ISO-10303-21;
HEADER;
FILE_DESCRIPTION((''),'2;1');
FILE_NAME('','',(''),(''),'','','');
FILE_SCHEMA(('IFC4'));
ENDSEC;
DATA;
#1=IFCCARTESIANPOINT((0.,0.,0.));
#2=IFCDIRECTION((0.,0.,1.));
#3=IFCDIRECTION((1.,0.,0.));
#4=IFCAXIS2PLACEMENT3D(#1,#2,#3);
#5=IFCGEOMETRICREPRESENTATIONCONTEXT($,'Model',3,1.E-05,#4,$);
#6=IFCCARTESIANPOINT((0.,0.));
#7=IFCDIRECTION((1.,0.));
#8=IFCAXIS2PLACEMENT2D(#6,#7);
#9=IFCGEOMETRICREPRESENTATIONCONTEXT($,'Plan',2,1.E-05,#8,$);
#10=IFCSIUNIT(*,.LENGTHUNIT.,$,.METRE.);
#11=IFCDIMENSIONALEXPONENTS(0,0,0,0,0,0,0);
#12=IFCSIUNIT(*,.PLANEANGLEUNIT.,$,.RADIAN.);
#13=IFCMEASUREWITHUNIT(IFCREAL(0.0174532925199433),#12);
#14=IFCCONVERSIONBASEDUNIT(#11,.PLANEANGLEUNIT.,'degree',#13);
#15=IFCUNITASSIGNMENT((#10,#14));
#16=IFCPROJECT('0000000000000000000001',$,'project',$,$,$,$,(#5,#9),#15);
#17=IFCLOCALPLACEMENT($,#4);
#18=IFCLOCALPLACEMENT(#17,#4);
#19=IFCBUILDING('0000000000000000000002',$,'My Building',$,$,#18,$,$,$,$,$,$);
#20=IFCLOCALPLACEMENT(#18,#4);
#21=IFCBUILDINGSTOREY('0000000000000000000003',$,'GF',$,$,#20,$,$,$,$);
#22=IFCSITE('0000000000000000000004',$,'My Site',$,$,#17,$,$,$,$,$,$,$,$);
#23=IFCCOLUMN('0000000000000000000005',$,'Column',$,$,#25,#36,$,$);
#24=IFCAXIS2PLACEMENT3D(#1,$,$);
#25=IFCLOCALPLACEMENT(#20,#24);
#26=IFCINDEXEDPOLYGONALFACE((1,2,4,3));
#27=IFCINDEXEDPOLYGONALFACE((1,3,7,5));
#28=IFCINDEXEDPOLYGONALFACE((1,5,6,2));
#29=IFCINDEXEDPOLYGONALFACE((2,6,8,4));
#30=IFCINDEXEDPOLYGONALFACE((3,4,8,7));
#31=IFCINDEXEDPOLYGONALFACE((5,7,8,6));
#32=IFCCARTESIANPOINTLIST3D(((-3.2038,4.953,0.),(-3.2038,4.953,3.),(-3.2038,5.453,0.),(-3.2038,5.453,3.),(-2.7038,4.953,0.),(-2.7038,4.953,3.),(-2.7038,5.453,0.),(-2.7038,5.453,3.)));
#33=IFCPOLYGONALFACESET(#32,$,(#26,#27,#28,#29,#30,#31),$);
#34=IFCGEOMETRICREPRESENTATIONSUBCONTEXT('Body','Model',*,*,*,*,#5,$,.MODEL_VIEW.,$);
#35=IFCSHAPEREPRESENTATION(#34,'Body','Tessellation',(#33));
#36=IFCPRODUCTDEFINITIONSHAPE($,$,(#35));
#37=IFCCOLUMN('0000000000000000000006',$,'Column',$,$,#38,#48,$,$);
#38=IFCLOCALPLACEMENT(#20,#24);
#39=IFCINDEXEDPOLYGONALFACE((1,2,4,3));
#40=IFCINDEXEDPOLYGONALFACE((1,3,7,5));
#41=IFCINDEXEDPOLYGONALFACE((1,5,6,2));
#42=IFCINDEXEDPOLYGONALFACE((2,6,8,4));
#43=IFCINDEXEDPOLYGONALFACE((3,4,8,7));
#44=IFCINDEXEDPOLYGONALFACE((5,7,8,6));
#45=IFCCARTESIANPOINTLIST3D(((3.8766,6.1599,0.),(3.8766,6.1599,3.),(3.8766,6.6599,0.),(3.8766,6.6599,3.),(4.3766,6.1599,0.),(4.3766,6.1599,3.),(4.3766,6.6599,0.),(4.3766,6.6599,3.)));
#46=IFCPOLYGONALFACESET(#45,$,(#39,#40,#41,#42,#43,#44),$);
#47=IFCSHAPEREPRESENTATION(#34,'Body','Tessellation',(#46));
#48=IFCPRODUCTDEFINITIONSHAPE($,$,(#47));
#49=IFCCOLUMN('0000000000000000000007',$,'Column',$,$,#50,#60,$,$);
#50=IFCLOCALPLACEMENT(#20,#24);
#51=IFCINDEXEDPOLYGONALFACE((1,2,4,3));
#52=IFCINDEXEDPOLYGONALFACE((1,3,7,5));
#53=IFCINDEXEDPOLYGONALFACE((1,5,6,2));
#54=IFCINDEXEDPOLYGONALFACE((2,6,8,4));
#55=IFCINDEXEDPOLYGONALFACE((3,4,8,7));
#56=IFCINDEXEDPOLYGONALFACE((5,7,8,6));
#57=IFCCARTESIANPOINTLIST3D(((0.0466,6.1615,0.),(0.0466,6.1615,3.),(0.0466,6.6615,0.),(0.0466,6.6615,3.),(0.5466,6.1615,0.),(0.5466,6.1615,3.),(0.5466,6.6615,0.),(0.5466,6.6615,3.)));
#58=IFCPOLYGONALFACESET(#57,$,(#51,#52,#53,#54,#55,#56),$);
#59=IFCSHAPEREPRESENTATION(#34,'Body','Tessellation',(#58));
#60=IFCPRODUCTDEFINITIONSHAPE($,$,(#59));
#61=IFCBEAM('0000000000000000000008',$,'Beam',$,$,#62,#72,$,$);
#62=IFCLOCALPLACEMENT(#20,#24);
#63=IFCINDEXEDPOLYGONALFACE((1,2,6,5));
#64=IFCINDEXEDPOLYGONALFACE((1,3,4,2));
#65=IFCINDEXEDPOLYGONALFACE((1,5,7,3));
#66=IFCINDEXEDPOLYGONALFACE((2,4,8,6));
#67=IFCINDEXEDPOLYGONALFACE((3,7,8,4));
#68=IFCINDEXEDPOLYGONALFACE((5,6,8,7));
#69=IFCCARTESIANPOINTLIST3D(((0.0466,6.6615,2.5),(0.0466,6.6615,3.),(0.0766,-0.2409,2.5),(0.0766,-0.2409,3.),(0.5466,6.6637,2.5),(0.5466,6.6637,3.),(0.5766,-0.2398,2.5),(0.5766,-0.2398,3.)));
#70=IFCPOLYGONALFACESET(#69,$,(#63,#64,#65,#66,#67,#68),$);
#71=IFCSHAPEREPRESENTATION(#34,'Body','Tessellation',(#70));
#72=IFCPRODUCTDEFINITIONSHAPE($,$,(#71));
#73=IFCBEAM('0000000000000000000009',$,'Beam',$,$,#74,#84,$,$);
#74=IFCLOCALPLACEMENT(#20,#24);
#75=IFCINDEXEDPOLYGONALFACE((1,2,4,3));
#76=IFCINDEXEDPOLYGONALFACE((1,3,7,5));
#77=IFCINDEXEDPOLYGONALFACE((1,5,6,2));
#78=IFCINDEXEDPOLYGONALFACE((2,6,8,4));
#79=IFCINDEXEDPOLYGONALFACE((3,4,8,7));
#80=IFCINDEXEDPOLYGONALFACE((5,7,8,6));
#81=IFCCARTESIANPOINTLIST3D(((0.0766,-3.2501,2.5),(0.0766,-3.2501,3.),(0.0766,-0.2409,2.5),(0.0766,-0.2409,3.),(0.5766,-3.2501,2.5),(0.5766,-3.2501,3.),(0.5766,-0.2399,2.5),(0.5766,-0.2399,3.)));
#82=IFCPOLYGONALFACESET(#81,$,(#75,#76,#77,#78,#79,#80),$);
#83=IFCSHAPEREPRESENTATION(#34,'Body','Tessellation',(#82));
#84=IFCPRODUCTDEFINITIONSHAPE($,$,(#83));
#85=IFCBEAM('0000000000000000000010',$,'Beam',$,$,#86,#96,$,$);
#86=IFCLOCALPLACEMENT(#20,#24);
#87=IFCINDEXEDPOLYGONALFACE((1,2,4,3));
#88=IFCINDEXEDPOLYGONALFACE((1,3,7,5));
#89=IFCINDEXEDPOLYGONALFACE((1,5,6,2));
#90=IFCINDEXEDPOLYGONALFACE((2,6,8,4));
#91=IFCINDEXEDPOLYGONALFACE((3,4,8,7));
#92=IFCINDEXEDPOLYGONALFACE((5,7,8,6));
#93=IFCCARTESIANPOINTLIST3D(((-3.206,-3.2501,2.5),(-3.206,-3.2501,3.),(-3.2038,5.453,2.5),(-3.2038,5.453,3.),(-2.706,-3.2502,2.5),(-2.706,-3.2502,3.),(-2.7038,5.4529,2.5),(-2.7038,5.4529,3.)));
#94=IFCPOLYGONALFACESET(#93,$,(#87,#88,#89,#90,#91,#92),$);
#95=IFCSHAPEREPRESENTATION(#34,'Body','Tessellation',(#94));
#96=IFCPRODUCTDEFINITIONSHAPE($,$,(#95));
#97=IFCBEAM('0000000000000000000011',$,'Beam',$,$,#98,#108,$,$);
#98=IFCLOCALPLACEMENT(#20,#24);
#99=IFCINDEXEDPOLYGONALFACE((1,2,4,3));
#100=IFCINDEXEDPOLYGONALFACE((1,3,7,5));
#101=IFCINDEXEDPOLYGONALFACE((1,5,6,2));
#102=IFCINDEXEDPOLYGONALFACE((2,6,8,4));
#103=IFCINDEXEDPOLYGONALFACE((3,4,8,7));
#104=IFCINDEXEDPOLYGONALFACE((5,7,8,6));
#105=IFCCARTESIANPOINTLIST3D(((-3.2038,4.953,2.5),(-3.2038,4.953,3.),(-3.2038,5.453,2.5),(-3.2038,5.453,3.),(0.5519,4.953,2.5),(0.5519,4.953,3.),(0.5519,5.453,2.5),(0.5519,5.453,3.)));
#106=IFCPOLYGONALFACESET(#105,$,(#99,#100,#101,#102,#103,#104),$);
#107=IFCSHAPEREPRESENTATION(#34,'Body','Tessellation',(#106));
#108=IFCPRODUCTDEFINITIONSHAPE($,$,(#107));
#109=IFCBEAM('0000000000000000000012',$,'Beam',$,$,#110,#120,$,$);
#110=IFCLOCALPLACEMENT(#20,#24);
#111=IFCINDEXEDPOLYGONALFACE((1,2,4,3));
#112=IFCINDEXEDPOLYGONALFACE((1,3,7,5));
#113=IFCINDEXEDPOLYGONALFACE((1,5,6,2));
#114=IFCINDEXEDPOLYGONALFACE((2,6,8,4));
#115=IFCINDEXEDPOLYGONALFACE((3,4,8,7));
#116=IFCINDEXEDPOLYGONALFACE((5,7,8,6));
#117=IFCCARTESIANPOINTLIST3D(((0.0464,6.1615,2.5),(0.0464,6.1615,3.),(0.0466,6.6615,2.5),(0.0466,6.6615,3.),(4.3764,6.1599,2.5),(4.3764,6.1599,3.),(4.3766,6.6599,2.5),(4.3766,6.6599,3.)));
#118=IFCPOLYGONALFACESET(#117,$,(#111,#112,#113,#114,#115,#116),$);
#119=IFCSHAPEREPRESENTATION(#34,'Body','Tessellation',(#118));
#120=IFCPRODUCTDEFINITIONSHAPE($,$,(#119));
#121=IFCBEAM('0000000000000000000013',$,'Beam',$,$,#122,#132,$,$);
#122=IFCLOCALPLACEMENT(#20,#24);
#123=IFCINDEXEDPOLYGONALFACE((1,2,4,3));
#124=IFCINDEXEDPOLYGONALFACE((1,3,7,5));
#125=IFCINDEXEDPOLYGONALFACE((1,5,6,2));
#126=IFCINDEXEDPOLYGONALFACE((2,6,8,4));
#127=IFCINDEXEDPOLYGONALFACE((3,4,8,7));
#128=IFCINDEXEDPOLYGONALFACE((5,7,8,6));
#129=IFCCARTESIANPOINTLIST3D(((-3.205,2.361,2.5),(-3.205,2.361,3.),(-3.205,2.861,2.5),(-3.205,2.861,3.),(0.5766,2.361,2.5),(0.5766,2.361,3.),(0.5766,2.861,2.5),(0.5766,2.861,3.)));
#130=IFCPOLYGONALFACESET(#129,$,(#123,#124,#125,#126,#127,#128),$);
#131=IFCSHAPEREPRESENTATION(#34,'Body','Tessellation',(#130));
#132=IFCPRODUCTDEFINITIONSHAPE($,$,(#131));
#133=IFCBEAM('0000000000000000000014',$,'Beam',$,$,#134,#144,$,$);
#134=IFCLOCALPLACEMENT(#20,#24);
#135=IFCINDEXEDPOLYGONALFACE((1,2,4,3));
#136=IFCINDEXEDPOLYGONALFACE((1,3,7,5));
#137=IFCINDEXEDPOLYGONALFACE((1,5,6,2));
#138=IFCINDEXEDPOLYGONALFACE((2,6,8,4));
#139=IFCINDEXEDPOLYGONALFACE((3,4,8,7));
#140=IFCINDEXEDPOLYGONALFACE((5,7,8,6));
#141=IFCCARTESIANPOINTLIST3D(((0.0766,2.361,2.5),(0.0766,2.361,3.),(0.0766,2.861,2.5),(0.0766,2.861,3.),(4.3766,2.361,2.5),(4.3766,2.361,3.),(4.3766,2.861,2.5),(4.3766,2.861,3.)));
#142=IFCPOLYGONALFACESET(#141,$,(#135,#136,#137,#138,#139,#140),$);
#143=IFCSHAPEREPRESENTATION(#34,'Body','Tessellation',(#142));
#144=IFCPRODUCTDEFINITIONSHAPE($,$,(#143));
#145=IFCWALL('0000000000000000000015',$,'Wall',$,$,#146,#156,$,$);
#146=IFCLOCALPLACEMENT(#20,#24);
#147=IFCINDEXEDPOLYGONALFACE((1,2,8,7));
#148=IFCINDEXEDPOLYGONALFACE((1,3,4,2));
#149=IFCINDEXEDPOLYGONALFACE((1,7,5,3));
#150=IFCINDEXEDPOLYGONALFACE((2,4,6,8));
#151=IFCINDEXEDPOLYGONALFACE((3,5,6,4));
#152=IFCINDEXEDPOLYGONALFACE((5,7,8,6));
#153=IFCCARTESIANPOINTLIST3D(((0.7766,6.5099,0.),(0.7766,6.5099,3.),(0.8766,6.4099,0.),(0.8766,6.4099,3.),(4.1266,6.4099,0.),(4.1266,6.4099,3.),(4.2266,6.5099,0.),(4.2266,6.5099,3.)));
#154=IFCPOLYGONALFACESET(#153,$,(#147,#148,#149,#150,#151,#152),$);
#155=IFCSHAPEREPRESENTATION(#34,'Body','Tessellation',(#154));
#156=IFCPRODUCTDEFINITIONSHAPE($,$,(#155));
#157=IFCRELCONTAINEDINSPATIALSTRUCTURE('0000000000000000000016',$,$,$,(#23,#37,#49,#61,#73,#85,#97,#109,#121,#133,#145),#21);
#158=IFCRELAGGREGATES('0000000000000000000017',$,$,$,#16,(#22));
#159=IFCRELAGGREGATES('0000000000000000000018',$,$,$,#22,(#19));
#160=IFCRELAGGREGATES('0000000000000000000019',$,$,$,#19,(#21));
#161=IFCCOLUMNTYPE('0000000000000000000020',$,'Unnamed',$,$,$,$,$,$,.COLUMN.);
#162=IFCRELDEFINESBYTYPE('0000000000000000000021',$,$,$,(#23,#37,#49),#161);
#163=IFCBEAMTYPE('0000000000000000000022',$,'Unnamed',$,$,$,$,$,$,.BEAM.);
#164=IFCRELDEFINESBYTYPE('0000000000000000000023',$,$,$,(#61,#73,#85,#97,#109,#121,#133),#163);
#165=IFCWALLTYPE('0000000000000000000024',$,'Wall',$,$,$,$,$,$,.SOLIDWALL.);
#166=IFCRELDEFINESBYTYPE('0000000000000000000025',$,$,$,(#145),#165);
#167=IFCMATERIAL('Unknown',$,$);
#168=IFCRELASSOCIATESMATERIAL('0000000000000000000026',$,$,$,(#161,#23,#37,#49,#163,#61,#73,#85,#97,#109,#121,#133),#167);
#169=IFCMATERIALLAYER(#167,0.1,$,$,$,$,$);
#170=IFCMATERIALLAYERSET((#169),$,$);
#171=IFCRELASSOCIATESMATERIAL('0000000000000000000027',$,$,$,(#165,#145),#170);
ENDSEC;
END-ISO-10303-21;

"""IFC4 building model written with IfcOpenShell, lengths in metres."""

from ifc_helpers import new_model, entity, si_unit, converted_unit, frame, origin_with_axes, origin_2d_with_axis, place, context, subcontext, project, spatial, line, indexed_curve, rectangle, outline, extrude, clip, halfspace, material, layer, layer_set, layer_usage, material_profile, profile_set, profile_usage, type_object, element, save


model = new_model("IFC4")

# Units and contexts
model_context = context("Model", 3, precision=1e-05, world=origin_with_axes())
plan_context = context("Plan", 2, precision=1e-05, world=origin_2d_with_axis())
body_context_1 = subcontext(model_context, "Body", "Model", "MODEL_VIEW")
ifc_project = project(units=[si_unit("LENGTHUNIT", "METRE"), converted_unit("PLANEANGLEUNIT", "degree", entity("IfcReal", 0.0174532925199433), si_unit("PLANEANGLEUNIT", "RADIAN"), dimensions=[0, 0, 0, 0, 0, 0, 0])], contexts=[model_context, plan_context])

# Site, building, storey
site_placement = place(None, origin_with_axes())
site = spatial("IfcSite", under=ifc_project, at=site_placement, Name="My Site")
building_placement = place(site_placement, origin_with_axes())
building = spatial("IfcBuilding", under=site, at=building_placement, Name="My Building")
storey_placement = place(building_placement, origin_with_axes())
storey = spatial("IfcBuildingStorey", under=building, at=storey_placement, Name="GF")

# Columns
ifc_material_1 = material(Name="Unknown")
ifc_material_profile_1 = material_profile(ifc_material_1, rectangle(XDim=0.5, YDim=0.5))
ifc_profile_set_1 = profile_set([ifc_material_profile_1])
ifc_profile_usage_1 = profile_usage(ifc_profile_set_1, cardinal=5)
column_type = type_object("IfcColumnType", Name="Unnamed", PredefinedType="COLUMN", material=ifc_profile_set_1)
column_1_placement = place(storey_placement, frame((-2.9538, 5.203, 0.0), z_axis=(0.0, 0.0, 1.0), x_axis=(1.0, 0.0, 0.0)))
element("IfcColumn", 1, at=column_1_placement, inside=storey, type_object=column_type, material=ifc_profile_usage_1, Name="Column", context=body_context_1, shape_type="SweptSolid", body=[
    extrude(rectangle(XDim=0.5, YDim=0.5), origin_with_axes(), (0.0, 0.0, 1.0), 3.0),
])
ifc_profile_usage_2 = profile_usage(ifc_profile_set_1, cardinal=5)
column_2_placement = place(storey_placement, frame((4.1266, 6.4099, 0.0), z_axis=(0.0, 0.0, 1.0), x_axis=(1.0, 0.0, 0.0)))
element("IfcColumn", 2, at=column_2_placement, inside=storey, type_object=column_type, material=ifc_profile_usage_2, Name="Column", context=body_context_1, shape_type="SweptSolid", body=[
    extrude(rectangle(XDim=0.5, YDim=0.5), origin_with_axes(), (0.0, 0.0, 1.0), 3.0),
])
ifc_profile_usage_3 = profile_usage(ifc_profile_set_1, cardinal=5)
column_3_placement = place(storey_placement, frame((0.2966, 6.4115, 0.0), z_axis=(0.0, 0.0, 1.0), x_axis=(1.0, 0.0, 0.0)))
element("IfcColumn", 3, at=column_3_placement, inside=storey, type_object=column_type, material=ifc_profile_usage_3, Name="Column", context=body_context_1, shape_type="SweptSolid", body=[
    extrude(rectangle(XDim=0.5, YDim=0.5), origin_with_axes(), (0.0, 0.0, 1.0), 3.0),
])

# Beams
ifc_material_profile_2 = material_profile(ifc_material_1, rectangle(XDim=0.5, YDim=0.5))
ifc_profile_set_2 = profile_set([ifc_material_profile_2])
ifc_profile_usage_4 = profile_usage(ifc_profile_set_2, cardinal=9)
beam_type = type_object("IfcBeamType", Name="Unnamed", PredefinedType="BEAM", material=ifc_profile_set_2)
beam_1_placement = place(storey_placement, frame((0.0466, 6.6615, 3.0), z_axis=(0.004356, -0.999991, 0.0), x_axis=(0.999991, 0.004356, 0.0)))
element("IfcBeam", 4, at=beam_1_placement, inside=storey, type_object=beam_type, material=ifc_profile_usage_4, Name="Beam", context=body_context_1, shape_type="Clipping", body=[
    clip(extrude(rectangle(XDim=0.5, YDim=0.5), frame((0.25, -0.25, 0.0), z_axis=(0.0, 0.0, 1.0), x_axis=(1.0, 0.0, 0.0)), (0.0, 0.0, 1.0), 121.9591), halfspace(frame((0.5, -3.0, 6.9036), z_axis=(-0.002196, 0.0, 0.999998), x_axis=(-0.999998, 0.0, -0.002196)), False)),
])
ifc_profile_usage_5 = profile_usage(ifc_profile_set_2, cardinal=9)
beam_2_placement = place(storey_placement, frame((0.0776, 114.8156, 3.0), z_axis=(-0.000009, -1.0, 0.0), x_axis=(1.0, -0.000009, 0.0)))
element("IfcBeam", 5, at=beam_2_placement, inside=storey, type_object=beam_type, material=ifc_profile_usage_5, Name="Beam", context=body_context_1, shape_type="Clipping", body=[
    clip(extrude(rectangle(XDim=0.5, YDim=0.5), frame((0.25, -0.25, 0.0), z_axis=(0.0, 0.0, 1.0), x_axis=(1.0, 0.0, 0.0)), (0.0, 0.0, 1.0), 118.0658), halfspace(frame((0.5, -3.0, 115.0555), z_axis=(-0.002169, 0.0, -0.999998), x_axis=(0.999998, 0.0, -0.002169)), False)),
])
ifc_profile_usage_6 = profile_usage(ifc_profile_set_2, cardinal=9)
beam_3_placement = place(storey_placement, frame((-3.2038, 5.453, 3.0), z_axis=(-0.000251, -1.0, 0.0), x_axis=(1.0, -0.000251, 0.0)))
element("IfcBeam", 6, at=beam_3_placement, inside=storey, type_object=beam_type, material=ifc_profile_usage_6, Name="Beam", context=body_context_1, shape_type="SweptSolid", body=[
    extrude(rectangle(XDim=0.5, YDim=0.5), frame((0.25, -0.25, 0.0), z_axis=(0.0, 0.0, 1.0), x_axis=(1.0, 0.0, 0.0)), (0.0, 0.0, 1.0), 8.7031),
])
ifc_profile_usage_7 = profile_usage(ifc_profile_set_2, cardinal=7)
beam_4_placement = place(storey_placement, frame((-3.2038, 5.453, 3.0), z_axis=(1.0, 0.0, 0.0), x_axis=(0.0, 1.0, 0.0)))
element("IfcBeam", 7, at=beam_4_placement, inside=storey, type_object=beam_type, material=ifc_profile_usage_7, Name="Beam", context=body_context_1, shape_type="SweptSolid", body=[
    extrude(rectangle(XDim=0.5, YDim=0.5), frame((-0.25, -0.25, 0.0), z_axis=(0.0, 0.0, 1.0), x_axis=(1.0, 0.0, 0.0)), (0.0, 0.0, 1.0), 3.7558),
])
ifc_profile_usage_8 = profile_usage(ifc_profile_set_2, cardinal=7)
beam_5_placement = place(storey_placement, frame((0.0466, 6.6615, 3.0), z_axis=(1.0, -0.000377, 0.0), x_axis=(0.000377, 1.0, 0.0)))
element("IfcBeam", 8, at=beam_5_placement, inside=storey, type_object=beam_type, material=ifc_profile_usage_8, Name="Beam", context=body_context_1, shape_type="SweptSolid", body=[
    extrude(rectangle(XDim=0.5, YDim=0.5), frame((-0.25, -0.25, 0.0), z_axis=(0.0, 0.0, 1.0), x_axis=(1.0, 0.0, 0.0)), (0.0, 0.0, 1.0), 4.33),
])
ifc_profile_usage_9 = profile_usage(ifc_profile_set_2, cardinal=7)
beam_6_placement = place(storey_placement, frame((-3.205, 2.861, 3.0), z_axis=(1.0, 0.000001, 0.0), x_axis=(-0.000001, 1.0, 0.0)))
element("IfcBeam", 9, at=beam_6_placement, inside=storey, type_object=beam_type, material=ifc_profile_usage_9, Name="Beam", context=body_context_1, shape_type="SweptSolid", body=[
    extrude(rectangle(XDim=0.5, YDim=0.5), frame((-0.25, -0.25, 0.0), z_axis=(0.0, 0.0, 1.0), x_axis=(1.0, 0.0, 0.0)), (0.0, 0.0, 1.0), 3.7816),
])
ifc_profile_usage_10 = profile_usage(ifc_profile_set_2, cardinal=7)
beam_7_placement = place(storey_placement, frame((0.0766, 2.861, 3.0), z_axis=(1.0, 0.0, 0.0), x_axis=(0.0, 1.0, 0.0)))
element("IfcBeam", 10, at=beam_7_placement, inside=storey, type_object=beam_type, material=ifc_profile_usage_10, Name="Beam", context=body_context_1, shape_type="SweptSolid", body=[
    extrude(rectangle(XDim=0.5, YDim=0.5), frame((-0.25, -0.25, 0.0), z_axis=(0.0, 0.0, 1.0), x_axis=(1.0, 0.0, 0.0)), (0.0, 0.0, 1.0), 4.3),
])

# Wall
ifc_layer_1 = layer(ifc_material_1, 0.1)
ifc_layer_set_1 = layer_set([ifc_layer_1])
ifc_layer_usage_1 = layer_usage(ifc_layer_set_1, "AXIS2", "POSITIVE", 0.0)
wall_type = type_object("IfcWallType", Name="Wall", PredefinedType="SOLIDWALL", material=ifc_layer_set_1)
wall_1_placement = place(storey_placement, frame((4.2266, 6.5099, 0.0), z_axis=(0.0, 0.0, 1.0), x_axis=(-1.0, 0.0, 0.0)))
element("IfcWall", 11, at=wall_1_placement, inside=storey, type_object=wall_type, material=ifc_layer_usage_1, Name="Wall", context=body_context_1, shape_type="SweptSolid", body=[
    extrude(outline(indexed_curve([(0.0, 0.0), (0.1, 0.1), (3.35, 0.1), (3.45, 0.0)], segments=[line(1, 2, 3, 4, 1)])), origin_with_axes(), (0.0, 0.0, 1.0), 3.0),
])

save(model, "model.ifc")
